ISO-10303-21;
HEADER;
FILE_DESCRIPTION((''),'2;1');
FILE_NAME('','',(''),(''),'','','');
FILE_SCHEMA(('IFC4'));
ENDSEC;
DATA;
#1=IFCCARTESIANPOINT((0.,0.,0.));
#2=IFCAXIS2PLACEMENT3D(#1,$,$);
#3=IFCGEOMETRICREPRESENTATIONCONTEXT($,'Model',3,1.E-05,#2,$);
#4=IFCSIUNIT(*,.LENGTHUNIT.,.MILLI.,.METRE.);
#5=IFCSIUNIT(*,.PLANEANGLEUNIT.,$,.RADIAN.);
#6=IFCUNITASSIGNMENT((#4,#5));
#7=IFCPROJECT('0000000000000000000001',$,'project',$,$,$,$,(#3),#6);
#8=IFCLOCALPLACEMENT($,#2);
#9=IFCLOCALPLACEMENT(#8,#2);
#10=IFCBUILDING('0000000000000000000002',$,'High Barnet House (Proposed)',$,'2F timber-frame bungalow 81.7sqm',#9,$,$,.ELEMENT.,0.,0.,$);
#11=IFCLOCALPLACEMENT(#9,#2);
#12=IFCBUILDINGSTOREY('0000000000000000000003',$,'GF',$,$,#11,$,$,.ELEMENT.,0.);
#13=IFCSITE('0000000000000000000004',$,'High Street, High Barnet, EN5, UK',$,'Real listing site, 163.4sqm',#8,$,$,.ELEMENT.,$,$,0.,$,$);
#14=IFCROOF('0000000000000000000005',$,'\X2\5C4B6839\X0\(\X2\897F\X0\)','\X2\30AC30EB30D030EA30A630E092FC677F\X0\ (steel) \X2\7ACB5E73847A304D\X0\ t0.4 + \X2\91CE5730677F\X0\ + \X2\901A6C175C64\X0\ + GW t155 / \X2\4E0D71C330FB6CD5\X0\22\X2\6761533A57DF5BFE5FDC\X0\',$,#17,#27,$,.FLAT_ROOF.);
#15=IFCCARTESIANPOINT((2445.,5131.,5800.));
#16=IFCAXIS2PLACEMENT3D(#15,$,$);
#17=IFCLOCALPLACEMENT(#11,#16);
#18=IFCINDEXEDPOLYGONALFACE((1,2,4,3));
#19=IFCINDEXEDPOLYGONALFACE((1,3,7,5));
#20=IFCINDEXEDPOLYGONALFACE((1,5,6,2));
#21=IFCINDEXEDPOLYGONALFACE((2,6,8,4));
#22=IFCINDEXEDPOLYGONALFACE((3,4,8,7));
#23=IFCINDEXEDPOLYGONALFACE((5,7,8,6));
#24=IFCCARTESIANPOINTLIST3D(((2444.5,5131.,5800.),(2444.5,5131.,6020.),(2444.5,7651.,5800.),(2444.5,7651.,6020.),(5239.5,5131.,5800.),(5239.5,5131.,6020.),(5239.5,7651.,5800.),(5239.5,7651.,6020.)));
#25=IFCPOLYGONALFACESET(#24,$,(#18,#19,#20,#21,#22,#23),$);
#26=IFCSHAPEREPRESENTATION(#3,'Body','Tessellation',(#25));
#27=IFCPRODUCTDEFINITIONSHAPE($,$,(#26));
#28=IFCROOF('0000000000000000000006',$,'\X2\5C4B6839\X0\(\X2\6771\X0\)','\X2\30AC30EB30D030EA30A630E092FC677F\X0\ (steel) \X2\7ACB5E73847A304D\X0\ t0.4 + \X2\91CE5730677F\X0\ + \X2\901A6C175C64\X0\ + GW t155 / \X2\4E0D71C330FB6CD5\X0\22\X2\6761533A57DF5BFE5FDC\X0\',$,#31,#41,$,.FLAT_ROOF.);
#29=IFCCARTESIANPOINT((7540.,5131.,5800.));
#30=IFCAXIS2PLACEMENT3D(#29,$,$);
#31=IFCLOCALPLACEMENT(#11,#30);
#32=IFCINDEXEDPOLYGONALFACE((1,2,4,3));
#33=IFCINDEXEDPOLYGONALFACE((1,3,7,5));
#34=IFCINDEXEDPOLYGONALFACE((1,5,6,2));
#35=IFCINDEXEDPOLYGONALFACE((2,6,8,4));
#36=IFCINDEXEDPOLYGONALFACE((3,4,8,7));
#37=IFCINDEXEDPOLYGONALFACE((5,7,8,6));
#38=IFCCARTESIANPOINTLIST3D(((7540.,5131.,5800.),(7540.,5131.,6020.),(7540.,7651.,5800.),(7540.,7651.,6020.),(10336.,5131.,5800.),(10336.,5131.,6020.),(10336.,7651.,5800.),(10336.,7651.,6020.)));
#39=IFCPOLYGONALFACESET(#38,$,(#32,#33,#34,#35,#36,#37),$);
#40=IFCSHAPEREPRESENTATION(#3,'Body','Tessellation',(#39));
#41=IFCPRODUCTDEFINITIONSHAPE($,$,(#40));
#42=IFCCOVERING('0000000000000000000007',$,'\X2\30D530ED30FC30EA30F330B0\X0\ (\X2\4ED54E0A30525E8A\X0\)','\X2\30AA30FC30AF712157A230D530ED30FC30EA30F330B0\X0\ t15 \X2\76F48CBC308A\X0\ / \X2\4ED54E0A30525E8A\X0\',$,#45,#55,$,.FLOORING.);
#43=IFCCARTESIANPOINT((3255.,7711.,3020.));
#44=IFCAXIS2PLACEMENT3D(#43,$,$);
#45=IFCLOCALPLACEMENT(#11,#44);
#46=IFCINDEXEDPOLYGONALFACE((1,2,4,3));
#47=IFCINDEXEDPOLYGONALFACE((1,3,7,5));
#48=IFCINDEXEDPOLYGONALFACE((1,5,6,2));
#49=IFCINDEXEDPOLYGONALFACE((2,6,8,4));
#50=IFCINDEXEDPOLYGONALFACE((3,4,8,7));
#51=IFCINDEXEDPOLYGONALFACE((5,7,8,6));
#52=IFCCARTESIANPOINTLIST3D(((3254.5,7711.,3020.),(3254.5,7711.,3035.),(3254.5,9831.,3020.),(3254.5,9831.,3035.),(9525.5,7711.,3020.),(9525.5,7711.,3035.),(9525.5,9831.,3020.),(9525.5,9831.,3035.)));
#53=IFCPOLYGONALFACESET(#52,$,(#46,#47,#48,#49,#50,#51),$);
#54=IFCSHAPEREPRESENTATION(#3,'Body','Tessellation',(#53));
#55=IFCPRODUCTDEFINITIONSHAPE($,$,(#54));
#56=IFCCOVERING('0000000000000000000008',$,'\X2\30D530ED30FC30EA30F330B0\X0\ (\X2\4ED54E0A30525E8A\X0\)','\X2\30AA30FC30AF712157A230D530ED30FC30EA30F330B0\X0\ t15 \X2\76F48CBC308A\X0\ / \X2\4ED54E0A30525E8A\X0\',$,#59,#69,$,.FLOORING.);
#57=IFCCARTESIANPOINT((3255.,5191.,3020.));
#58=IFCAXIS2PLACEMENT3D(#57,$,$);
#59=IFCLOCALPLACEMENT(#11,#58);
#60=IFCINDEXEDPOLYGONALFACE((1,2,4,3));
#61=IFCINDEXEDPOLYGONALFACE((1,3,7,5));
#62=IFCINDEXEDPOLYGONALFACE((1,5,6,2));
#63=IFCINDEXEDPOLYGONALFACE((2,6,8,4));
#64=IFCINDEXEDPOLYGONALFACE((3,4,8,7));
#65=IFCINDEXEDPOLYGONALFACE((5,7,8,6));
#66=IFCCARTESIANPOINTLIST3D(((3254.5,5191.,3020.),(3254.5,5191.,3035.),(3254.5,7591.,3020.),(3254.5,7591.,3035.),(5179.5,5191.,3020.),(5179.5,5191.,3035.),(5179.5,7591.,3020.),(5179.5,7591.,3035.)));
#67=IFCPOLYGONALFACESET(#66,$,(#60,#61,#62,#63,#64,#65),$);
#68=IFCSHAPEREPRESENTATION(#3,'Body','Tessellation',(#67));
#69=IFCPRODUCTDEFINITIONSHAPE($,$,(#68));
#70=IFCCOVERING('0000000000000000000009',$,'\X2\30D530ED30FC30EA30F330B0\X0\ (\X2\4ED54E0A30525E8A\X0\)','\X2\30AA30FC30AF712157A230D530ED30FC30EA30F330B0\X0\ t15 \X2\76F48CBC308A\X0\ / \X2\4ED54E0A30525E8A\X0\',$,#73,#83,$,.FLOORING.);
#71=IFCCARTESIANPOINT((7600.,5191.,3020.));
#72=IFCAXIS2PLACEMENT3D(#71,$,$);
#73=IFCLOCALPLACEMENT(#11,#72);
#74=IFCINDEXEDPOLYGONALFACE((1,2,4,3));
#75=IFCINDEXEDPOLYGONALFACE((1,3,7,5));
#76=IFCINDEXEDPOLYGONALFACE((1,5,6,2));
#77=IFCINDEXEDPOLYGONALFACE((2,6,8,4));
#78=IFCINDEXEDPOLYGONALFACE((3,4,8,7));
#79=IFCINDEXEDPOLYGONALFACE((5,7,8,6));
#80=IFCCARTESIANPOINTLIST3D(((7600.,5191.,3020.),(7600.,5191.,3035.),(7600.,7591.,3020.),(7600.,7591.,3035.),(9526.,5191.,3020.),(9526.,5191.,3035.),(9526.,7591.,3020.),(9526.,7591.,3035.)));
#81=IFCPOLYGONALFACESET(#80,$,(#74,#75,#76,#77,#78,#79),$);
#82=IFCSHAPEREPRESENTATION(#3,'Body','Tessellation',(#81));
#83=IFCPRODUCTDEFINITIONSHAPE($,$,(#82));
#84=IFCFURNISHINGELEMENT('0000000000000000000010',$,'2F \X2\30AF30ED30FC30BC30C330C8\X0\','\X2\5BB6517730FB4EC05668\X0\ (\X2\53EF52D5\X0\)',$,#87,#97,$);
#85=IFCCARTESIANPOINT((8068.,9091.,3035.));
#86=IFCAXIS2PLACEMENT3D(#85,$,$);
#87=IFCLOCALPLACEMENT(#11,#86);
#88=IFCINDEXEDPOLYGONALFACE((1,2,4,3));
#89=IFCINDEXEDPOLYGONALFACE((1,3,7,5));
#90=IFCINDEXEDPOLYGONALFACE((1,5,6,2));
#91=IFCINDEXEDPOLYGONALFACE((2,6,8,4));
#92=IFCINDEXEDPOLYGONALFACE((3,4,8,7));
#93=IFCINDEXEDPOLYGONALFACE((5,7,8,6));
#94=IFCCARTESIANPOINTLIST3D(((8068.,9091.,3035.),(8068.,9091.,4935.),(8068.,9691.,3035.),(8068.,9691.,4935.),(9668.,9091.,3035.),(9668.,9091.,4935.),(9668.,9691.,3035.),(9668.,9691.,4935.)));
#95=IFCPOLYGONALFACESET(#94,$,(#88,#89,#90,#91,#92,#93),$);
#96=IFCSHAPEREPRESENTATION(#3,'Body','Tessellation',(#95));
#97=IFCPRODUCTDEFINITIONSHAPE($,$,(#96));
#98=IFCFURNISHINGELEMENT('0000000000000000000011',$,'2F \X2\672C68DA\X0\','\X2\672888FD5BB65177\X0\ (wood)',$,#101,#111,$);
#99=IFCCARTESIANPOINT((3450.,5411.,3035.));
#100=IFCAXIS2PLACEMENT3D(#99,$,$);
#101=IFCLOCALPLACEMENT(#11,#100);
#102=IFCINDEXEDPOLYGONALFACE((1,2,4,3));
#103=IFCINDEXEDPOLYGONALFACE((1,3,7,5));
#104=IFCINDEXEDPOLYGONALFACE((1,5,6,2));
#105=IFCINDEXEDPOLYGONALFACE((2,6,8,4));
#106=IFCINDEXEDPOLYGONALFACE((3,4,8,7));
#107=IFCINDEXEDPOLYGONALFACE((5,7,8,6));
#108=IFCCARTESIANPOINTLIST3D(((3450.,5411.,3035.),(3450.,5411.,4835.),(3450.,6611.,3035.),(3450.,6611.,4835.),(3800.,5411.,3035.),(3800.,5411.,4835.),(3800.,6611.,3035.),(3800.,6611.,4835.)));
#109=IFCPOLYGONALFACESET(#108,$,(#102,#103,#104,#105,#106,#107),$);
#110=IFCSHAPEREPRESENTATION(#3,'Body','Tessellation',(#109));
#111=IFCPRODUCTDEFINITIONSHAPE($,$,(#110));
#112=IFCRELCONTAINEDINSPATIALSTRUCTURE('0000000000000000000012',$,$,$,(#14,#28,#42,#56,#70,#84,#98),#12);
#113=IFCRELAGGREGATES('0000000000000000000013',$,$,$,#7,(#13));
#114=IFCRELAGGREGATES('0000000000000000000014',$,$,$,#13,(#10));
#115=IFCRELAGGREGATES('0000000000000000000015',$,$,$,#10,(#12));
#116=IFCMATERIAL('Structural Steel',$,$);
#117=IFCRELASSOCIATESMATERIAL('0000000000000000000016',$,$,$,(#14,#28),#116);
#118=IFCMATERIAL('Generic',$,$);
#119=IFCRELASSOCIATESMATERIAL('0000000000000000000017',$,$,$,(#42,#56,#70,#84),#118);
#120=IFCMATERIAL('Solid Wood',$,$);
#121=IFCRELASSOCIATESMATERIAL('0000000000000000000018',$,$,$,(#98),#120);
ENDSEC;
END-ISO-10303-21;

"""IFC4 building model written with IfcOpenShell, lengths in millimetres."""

from ifc_helpers import new_model, si_unit, frame, frame_2d, origin, place, context, project, spatial, rectangle, extrude, material, element, save


model = new_model("IFC4")

# Units and contexts
model_context = context("Model", 3, precision=1e-05, world=origin())
ifc_project = project(units=[si_unit("LENGTHUNIT", "METRE", prefix="MILLI"), si_unit("PLANEANGLEUNIT", "RADIAN")], contexts=[model_context])

# Site, building, storey
site_placement = place(None, origin())
site = spatial("IfcSite", under=ifc_project, at=site_placement, Name="High Street, High Barnet, EN5, UK", ObjectType="Real listing site, 163.4sqm", CompositionType="ELEMENT", RefElevation=0.0)
building_placement = place(site_placement, origin())
building = spatial("IfcBuilding", under=site, at=building_placement, Name="High Barnet House (Proposed)", ObjectType="2F timber-frame bungalow 81.7sqm", CompositionType="ELEMENT", ElevationOfRefHeight=0.0, ElevationOfTerrain=0.0)
storey_placement = place(building_placement, origin())
storey = spatial("IfcBuildingStorey", under=building, at=storey_placement, Name="GF", CompositionType="ELEMENT", Elevation=0.0)

# Shared definitions
ifc_material_1 = material(Name="Solid Wood")

# Roofs
ifc_material_2 = material(Name="Structural Steel")
roof_1_placement = place(storey_placement, frame((2445.0, 5131.0, 5800.0)))
element("IfcRoof", 1, at=roof_1_placement, inside=storey, material=ifc_material_2, Name="屋根(西)", Description="ガルバリウム鋼板 (steel) 立平葺き t0.4 + 野地板 + 通気層 + GW t155 / 不燃・法22条区域対応", PredefinedType="FLAT_ROOF", context=model_context, shape_type="SweptSolid", body=[
    extrude(rectangle(XDim=2795.0, YDim=2520.0, at=frame_2d((1397.0, 1260.0))), frame((2445.0, 5131.0, 5800.0)), (0.0, 0.0, 1.0), 220.0),
])
roof_2_placement = place(storey_placement, frame((7540.0, 5131.0, 5800.0)))
element("IfcRoof", 2, at=roof_2_placement, inside=storey, material=ifc_material_2, Name="屋根(東)", Description="ガルバリウム鋼板 (steel) 立平葺き t0.4 + 野地板 + 通気層 + GW t155 / 不燃・法22条区域対応", PredefinedType="FLAT_ROOF", context=model_context, shape_type="SweptSolid", body=[
    extrude(rectangle(XDim=2796.0, YDim=2520.0, at=frame_2d((1398.0, 1260.0))), frame((7540.0, 5131.0, 5800.0)), (0.0, 0.0, 1.0), 220.0),
])

# Coverings
ifc_material_3 = material(Name="Generic")
covering_1_placement = place(storey_placement, frame((3255.0, 7711.0, 3020.0)))
element("IfcCovering", 3, at=covering_1_placement, inside=storey, material=ifc_material_3, Name="フローリング (仕上げ床)", Description="オーク無垢フローリング t15 直貼り / 仕上げ床", PredefinedType="FLOORING", context=model_context, shape_type="SweptSolid", body=[
    extrude(rectangle(XDim=6271.0, YDim=2120.0, at=frame_2d((3135.0, 1060.0))), frame((3255.0, 7711.0, 3020.0)), (0.0, 0.0, 1.0), 15.0),
])
covering_2_placement = place(storey_placement, frame((3255.0, 5191.0, 3020.0)))
element("IfcCovering", 4, at=covering_2_placement, inside=storey, material=ifc_material_3, Name="フローリング (仕上げ床)", Description="オーク無垢フローリング t15 直貼り / 仕上げ床", PredefinedType="FLOORING", context=model_context, shape_type="SweptSolid", body=[
    extrude(rectangle(XDim=1925.0, YDim=2400.0, at=frame_2d((962.0, 1200.0))), frame((3255.0, 5191.0, 3020.0)), (0.0, 0.0, 1.0), 15.0),
])
covering_3_placement = place(storey_placement, frame((7600.0, 5191.0, 3020.0)))
element("IfcCovering", 5, at=covering_3_placement, inside=storey, material=ifc_material_3, Name="フローリング (仕上げ床)", Description="オーク無垢フローリング t15 直貼り / 仕上げ床", PredefinedType="FLOORING", context=model_context, shape_type="SweptSolid", body=[
    extrude(rectangle(XDim=1926.0, YDim=2400.0, at=frame_2d((963.0, 1200.0))), frame((7600.0, 5191.0, 3020.0)), (0.0, 0.0, 1.0), 15.0),
])

# Furnishing elements
furnishing_1_placement = place(storey_placement, frame((8068.0, 9091.0, 3035.0)))
element("IfcFurnishingElement", 6, at=furnishing_1_placement, inside=storey, material=ifc_material_3, Name="2F クローゼット", Description="家具・什器 (可動)", context=model_context, shape_type="SweptSolid", body=[
    extrude(rectangle(XDim=1600.0, YDim=600.0, at=frame_2d((800.0, 300.0))), frame((8068.0, 9091.0, 3035.0)), (0.0, 0.0, 1.0), 1900.0),
])
furnishing_2_placement = place(storey_placement, frame((3450.0, 5411.0, 3035.0)))
element("IfcFurnishingElement", 7, at=furnishing_2_placement, inside=storey, material=ifc_material_1, Name="2F 本棚", Description="木製家具 (wood)", context=model_context, shape_type="SweptSolid", body=[
    extrude(rectangle(XDim=350.0, YDim=1200.0, at=frame_2d((175.0, 600.0))), frame((3450.0, 5411.0, 3035.0)), (0.0, 0.0, 1.0), 1800.0),
])

save(model, "model.ifc")
